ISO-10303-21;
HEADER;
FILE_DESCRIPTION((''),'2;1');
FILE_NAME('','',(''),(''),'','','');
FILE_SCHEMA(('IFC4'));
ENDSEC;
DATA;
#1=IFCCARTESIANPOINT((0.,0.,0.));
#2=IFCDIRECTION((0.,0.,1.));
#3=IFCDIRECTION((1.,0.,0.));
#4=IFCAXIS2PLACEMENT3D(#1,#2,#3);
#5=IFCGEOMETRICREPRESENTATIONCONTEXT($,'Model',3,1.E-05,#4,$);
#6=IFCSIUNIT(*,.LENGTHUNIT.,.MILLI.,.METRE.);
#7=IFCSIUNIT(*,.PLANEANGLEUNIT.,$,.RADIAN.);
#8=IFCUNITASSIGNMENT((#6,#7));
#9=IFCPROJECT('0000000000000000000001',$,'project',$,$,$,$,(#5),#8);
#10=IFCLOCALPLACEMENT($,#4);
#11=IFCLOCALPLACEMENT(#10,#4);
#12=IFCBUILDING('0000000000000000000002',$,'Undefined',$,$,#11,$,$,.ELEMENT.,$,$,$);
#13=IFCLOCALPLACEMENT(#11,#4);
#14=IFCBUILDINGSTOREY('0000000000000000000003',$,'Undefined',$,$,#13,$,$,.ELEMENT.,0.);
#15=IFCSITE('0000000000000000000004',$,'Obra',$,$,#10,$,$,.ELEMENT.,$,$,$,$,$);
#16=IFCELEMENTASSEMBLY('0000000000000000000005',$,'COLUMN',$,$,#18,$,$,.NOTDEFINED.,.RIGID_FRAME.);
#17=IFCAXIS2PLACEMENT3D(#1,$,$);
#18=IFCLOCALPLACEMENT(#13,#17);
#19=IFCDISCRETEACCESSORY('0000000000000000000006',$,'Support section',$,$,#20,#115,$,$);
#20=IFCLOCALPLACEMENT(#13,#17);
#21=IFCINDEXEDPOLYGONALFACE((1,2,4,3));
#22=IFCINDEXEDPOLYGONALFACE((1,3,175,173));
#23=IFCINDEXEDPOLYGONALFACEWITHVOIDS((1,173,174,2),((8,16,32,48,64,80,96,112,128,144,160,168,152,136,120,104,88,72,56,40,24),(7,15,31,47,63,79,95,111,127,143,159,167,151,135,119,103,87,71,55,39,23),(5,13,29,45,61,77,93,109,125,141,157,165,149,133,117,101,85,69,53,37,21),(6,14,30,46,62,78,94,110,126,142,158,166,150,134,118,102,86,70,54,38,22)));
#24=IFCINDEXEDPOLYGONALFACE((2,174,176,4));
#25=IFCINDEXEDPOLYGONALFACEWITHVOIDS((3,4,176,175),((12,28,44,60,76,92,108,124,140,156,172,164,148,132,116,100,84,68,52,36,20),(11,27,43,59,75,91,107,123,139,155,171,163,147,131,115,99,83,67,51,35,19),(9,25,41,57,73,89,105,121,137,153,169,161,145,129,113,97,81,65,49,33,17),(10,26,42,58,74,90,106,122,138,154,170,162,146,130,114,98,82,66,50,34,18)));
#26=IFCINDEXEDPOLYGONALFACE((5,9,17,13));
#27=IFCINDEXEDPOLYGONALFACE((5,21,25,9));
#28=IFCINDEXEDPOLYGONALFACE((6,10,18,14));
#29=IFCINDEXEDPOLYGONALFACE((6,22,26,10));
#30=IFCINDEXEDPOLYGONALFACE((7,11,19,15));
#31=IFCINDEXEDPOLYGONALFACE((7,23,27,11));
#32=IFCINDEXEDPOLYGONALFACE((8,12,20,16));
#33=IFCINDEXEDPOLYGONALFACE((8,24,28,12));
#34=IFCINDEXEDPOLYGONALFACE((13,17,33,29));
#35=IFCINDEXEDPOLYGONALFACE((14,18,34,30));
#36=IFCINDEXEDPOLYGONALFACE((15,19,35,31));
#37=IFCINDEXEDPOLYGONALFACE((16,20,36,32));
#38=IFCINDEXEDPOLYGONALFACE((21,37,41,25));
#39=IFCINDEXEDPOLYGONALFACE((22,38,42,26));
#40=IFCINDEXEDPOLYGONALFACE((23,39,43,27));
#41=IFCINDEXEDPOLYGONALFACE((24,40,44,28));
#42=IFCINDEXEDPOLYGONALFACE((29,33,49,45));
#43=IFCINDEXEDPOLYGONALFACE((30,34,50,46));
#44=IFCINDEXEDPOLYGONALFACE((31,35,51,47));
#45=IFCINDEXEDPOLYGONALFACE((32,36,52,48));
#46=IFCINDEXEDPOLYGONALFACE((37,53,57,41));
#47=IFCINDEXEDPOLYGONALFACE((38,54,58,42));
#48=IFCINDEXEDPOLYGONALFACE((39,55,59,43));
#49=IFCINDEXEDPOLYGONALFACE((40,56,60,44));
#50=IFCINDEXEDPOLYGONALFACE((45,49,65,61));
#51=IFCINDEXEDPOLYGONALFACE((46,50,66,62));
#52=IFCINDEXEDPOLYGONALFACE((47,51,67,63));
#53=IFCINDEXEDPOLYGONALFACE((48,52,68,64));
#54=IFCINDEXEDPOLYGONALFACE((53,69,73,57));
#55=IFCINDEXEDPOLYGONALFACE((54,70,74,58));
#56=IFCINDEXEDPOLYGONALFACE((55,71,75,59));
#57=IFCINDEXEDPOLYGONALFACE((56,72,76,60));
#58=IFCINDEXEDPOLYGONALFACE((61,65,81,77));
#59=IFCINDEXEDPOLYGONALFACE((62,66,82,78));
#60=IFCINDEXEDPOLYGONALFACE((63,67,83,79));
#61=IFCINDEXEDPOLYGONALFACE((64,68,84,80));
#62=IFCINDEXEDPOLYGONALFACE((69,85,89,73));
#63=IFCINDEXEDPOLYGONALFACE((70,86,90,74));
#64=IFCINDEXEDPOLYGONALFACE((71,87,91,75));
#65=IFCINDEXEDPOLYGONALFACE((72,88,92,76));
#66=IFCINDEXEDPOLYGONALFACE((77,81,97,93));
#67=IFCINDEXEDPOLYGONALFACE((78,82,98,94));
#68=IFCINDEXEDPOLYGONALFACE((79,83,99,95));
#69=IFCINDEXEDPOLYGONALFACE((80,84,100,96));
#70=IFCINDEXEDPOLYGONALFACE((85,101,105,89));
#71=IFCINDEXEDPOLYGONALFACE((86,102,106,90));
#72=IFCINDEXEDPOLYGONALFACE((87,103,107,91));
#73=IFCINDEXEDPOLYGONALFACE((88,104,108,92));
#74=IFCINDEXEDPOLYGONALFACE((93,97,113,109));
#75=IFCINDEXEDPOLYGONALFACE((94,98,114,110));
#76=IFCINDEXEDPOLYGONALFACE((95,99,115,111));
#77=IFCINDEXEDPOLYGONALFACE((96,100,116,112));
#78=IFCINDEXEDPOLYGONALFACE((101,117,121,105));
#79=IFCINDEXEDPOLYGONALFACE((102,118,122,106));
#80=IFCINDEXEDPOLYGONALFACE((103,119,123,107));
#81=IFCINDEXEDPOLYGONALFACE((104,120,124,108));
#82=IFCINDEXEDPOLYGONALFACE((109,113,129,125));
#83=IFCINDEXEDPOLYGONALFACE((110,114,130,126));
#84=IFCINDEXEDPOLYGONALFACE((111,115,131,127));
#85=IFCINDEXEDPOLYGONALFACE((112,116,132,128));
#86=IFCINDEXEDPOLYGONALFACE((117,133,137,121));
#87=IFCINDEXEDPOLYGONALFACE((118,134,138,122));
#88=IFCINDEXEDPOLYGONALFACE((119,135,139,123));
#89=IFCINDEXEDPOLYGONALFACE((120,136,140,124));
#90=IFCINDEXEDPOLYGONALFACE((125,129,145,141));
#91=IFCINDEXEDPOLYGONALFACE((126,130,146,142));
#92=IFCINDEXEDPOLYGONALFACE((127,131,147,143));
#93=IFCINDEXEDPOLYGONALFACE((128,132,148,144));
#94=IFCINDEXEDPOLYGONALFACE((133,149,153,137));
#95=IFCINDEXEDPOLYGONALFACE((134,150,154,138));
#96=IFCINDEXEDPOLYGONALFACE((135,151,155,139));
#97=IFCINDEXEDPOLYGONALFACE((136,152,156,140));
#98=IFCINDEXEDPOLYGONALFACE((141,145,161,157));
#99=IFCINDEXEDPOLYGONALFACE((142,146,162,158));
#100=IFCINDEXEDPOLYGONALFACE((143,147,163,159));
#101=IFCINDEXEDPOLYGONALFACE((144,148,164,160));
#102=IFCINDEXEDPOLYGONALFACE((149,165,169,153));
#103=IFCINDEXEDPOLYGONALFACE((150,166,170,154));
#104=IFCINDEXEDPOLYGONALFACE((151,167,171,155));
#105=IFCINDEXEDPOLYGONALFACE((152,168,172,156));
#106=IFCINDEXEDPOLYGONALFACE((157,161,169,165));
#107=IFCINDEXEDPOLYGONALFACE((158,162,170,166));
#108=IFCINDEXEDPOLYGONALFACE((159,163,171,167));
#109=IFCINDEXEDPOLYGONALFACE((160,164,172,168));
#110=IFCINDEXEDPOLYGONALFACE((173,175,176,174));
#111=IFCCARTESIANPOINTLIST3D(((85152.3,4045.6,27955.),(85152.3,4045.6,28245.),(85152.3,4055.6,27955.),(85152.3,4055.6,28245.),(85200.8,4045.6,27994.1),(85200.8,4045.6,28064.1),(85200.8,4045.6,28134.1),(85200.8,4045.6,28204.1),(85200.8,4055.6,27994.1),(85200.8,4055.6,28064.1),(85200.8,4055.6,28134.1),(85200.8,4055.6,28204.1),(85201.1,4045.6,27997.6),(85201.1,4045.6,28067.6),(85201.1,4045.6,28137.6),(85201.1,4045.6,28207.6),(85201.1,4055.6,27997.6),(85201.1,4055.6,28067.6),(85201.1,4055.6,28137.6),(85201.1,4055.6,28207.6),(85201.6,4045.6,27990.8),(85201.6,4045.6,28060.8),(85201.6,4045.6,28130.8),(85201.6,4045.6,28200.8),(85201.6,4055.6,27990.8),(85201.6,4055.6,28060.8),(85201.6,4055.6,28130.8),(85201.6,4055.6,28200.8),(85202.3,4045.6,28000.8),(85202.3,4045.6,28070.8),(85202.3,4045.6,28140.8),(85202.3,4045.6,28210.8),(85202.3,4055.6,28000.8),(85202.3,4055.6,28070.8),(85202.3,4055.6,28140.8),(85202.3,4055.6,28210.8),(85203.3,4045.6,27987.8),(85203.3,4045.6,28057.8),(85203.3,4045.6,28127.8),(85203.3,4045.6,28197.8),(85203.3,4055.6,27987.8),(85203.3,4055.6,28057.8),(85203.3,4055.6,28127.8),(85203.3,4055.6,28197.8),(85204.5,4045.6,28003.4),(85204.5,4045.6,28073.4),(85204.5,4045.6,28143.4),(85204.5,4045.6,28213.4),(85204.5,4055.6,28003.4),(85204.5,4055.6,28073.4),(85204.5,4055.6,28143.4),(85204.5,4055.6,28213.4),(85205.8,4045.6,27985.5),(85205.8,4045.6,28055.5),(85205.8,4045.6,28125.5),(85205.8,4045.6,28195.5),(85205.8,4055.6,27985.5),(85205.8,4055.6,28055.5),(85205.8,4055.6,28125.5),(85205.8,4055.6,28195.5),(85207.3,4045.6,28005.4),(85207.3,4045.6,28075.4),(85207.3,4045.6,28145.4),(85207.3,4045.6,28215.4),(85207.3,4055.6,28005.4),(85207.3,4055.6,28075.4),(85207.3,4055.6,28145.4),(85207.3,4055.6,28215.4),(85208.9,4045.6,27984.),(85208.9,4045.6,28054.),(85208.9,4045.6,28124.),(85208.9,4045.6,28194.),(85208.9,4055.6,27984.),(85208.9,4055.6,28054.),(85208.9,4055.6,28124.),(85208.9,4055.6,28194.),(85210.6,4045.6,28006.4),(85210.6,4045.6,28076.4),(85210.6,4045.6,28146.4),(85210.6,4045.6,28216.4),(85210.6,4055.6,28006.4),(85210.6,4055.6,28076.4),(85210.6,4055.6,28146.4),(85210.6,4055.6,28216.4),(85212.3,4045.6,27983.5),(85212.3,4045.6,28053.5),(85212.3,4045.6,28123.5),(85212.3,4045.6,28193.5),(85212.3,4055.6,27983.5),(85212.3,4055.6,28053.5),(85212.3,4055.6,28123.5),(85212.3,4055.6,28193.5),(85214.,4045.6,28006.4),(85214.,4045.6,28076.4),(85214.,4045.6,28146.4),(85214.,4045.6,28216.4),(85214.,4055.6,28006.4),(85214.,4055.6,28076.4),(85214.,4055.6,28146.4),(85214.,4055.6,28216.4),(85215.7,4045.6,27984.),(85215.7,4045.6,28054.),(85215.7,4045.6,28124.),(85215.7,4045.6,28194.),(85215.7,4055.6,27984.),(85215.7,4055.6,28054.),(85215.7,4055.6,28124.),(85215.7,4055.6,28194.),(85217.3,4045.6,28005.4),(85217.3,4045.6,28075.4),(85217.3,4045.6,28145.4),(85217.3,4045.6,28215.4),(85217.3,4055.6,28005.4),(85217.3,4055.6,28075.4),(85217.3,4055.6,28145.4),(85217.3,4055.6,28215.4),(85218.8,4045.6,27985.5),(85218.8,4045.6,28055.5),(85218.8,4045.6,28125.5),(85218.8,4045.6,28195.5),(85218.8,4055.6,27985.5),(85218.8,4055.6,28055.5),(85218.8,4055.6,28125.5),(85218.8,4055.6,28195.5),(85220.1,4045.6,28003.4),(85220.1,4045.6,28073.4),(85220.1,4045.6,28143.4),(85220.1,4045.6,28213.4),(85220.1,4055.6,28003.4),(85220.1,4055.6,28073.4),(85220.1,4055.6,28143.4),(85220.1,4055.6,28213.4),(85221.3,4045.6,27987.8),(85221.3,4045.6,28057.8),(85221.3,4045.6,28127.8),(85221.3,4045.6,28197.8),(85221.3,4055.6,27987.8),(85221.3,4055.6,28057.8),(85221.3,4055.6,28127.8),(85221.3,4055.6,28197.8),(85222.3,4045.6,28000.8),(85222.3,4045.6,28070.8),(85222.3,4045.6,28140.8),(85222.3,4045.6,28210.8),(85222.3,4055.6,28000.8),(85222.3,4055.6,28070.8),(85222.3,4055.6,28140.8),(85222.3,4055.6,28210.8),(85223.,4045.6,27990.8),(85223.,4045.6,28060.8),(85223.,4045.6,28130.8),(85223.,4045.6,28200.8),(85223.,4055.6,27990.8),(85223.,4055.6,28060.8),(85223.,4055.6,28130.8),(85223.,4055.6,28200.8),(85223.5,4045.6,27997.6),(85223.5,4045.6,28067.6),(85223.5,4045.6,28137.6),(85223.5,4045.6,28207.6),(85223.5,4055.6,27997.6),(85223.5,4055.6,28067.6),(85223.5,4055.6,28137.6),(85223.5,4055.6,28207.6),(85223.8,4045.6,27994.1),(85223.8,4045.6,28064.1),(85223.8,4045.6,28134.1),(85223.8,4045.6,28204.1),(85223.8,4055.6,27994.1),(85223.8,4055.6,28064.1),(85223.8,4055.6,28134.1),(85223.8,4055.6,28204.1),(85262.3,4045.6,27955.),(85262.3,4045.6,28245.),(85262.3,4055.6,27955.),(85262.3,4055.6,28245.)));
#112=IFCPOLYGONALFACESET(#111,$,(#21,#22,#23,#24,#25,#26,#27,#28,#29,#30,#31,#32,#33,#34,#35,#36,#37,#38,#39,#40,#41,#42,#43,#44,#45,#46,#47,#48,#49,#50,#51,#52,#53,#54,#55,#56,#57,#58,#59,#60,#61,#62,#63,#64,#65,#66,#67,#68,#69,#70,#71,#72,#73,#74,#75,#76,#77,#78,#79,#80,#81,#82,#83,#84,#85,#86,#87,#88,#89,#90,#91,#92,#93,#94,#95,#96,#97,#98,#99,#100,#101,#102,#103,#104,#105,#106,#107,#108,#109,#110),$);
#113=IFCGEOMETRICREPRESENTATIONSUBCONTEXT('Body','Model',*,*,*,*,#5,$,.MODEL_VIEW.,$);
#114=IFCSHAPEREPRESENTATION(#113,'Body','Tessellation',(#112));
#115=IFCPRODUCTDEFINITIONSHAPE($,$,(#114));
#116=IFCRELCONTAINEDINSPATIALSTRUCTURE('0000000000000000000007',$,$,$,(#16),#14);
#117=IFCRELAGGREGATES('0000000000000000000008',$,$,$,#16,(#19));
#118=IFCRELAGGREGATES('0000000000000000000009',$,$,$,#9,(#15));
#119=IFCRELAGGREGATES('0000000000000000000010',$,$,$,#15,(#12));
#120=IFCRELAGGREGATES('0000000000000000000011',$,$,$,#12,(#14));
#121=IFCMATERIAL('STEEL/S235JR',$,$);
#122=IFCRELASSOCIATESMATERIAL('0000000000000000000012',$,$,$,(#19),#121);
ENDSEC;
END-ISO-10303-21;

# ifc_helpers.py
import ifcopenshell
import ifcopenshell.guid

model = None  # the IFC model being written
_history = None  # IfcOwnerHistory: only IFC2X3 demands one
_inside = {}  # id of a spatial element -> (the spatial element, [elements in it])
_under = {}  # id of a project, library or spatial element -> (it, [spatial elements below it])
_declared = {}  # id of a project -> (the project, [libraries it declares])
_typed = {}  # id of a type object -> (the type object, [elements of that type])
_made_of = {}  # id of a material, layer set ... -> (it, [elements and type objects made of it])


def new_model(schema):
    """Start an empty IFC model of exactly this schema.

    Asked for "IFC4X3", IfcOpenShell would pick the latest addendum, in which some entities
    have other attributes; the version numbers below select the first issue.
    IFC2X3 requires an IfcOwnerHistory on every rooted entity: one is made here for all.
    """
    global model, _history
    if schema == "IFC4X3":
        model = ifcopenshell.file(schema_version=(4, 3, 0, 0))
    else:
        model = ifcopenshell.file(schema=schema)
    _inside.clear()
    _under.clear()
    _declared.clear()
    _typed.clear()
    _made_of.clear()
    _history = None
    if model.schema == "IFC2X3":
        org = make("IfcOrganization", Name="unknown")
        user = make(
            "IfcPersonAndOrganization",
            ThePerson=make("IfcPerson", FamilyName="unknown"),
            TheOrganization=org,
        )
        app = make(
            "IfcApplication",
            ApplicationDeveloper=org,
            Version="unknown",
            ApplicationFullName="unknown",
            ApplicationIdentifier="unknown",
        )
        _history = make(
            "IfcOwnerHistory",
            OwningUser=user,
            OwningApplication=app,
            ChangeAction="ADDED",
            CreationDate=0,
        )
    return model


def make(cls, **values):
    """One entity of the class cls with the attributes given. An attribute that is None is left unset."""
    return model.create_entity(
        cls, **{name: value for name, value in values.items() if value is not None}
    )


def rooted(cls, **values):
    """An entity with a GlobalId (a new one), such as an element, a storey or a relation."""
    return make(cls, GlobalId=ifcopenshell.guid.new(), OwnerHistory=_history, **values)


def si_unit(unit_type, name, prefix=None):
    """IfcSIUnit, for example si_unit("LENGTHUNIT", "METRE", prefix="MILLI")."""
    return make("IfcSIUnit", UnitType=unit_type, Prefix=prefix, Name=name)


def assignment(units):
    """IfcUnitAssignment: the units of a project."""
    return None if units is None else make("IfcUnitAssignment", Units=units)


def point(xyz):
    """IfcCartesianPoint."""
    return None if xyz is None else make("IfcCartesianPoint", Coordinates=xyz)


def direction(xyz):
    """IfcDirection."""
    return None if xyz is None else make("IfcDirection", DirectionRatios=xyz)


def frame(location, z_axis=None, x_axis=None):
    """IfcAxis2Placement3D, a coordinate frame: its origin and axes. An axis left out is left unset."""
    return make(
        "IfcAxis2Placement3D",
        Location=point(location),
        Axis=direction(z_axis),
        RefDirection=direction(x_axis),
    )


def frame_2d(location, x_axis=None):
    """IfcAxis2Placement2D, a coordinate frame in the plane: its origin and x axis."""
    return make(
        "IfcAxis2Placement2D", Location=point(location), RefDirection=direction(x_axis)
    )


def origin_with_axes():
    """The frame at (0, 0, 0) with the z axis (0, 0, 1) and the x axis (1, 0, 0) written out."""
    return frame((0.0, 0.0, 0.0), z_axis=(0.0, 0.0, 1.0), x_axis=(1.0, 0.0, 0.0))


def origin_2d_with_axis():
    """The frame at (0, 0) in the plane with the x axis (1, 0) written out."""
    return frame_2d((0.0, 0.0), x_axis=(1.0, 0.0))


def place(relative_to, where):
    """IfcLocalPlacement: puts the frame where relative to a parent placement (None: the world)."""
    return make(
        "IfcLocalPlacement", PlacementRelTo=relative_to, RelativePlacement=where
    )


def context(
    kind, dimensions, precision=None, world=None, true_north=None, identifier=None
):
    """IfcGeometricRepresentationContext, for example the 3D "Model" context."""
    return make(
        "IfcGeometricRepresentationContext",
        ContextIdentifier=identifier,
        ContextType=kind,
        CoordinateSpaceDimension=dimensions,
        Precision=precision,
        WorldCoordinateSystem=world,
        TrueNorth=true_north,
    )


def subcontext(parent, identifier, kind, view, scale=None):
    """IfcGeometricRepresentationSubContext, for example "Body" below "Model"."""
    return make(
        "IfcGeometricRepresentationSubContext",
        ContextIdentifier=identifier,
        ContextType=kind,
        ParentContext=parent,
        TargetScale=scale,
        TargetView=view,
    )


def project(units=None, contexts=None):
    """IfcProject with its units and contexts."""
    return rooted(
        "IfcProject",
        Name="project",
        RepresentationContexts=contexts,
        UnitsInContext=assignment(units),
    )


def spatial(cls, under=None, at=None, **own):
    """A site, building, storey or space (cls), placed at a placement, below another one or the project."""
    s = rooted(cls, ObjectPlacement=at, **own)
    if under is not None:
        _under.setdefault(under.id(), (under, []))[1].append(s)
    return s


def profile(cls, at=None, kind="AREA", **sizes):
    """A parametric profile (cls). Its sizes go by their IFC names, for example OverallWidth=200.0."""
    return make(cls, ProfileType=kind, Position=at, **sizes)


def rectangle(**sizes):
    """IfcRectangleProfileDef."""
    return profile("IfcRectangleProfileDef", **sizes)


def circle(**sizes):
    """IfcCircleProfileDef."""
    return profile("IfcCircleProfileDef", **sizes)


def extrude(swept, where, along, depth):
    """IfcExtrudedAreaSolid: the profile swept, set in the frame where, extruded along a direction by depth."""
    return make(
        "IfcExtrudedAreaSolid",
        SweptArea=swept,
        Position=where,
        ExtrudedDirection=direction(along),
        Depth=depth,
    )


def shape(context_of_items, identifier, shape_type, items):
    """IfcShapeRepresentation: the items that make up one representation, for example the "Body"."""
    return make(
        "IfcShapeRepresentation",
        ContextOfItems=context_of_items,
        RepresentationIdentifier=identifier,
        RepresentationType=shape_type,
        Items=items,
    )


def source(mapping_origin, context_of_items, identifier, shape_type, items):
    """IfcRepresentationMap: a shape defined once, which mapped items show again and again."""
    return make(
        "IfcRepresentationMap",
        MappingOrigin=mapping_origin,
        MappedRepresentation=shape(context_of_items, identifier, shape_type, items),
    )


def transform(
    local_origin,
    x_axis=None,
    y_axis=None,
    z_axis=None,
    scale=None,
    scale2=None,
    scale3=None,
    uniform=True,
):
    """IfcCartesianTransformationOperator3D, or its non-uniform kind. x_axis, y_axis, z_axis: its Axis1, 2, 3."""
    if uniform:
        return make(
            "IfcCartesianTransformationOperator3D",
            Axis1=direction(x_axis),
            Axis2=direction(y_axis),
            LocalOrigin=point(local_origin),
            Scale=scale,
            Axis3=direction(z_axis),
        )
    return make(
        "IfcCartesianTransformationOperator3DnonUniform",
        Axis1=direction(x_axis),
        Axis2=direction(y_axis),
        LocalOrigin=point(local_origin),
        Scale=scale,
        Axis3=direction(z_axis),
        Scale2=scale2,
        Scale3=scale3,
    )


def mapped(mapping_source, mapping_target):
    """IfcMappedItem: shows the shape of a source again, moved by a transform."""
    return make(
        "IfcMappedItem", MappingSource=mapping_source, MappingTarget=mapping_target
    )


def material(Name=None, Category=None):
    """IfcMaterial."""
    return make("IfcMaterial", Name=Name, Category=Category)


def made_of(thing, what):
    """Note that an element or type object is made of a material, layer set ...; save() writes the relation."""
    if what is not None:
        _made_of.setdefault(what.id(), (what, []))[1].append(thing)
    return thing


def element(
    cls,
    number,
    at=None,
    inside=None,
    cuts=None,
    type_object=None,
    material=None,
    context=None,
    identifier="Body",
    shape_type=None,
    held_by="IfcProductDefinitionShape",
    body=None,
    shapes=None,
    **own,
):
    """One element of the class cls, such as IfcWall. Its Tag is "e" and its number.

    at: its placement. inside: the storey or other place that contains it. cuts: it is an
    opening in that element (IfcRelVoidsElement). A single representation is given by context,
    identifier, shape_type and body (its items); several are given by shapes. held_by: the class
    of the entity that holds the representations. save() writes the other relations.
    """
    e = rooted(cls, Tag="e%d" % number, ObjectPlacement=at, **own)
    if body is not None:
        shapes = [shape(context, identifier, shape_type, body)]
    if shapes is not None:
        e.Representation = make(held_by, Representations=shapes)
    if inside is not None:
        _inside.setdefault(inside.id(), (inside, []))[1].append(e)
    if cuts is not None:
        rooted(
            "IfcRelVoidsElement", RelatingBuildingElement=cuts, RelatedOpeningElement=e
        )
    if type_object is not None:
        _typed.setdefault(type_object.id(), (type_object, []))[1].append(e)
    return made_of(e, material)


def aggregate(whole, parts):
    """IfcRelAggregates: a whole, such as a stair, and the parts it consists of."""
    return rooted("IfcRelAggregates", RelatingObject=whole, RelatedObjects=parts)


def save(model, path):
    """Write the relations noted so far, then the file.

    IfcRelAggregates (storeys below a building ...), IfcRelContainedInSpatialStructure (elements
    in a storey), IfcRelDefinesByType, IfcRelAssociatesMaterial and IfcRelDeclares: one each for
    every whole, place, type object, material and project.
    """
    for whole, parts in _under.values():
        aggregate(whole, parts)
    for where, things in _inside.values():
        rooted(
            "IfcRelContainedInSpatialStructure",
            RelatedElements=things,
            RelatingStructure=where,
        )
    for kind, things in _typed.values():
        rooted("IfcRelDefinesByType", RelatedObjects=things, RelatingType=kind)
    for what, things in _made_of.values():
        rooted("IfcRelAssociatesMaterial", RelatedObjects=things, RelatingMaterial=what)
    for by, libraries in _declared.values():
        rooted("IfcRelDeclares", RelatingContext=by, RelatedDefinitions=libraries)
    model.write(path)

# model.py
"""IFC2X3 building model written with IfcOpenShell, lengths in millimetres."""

from ifc_helpers import new_model, si_unit, frame, origin_with_axes, origin_2d_with_axis, place, context, subcontext, project, spatial, rectangle, circle, extrude, source, transform, mapped, material, element, aggregate, save


model = new_model("IFC2X3")

# Units and contexts
model_context = context("Model", 3, precision=1e-05, world=origin_with_axes())
body_context = subcontext(model_context, "Body", "Model", "MODEL_VIEW")
ifc_project = project(units=[si_unit("LENGTHUNIT", "METRE", prefix="MILLI"), si_unit("PLANEANGLEUNIT", "RADIAN")], contexts=[model_context])

# Site, building, storey
site_placement = place(None, origin_with_axes())
site = spatial("IfcSite", under=ifc_project, at=site_placement, Name="Obra", CompositionType="ELEMENT")
building_placement = place(site_placement, origin_with_axes())
building = spatial("IfcBuilding", under=site, at=building_placement, Name="Undefined", CompositionType="ELEMENT")
storey_placement = place(building_placement, origin_with_axes())
storey = spatial("IfcBuildingStorey", under=building, at=storey_placement, Name="Undefined", CompositionType="ELEMENT", Elevation=0.0)

# Shared definitions
ifc_material = material(Name="STEEL/S235JR")

# Shared definitions
shared_shape_1 = source(origin_with_axes(), body_context, "Body", "SweptSolid", [
    extrude(circle(Radius=11.5, at=origin_2d_with_axis()), frame((0.0, -14.4, 0.0), z_axis=(0.0, 1.0, 0.0), x_axis=(1.0, 0.0, 0.0)), (0.0, 0.0, 1.0), 10.2),
])

# Element assembly, discrete accessory, opening
assembly_1_placement = place(storey_placement, origin_with_axes())
assembly_1 = element("IfcElementAssembly", 1, at=assembly_1_placement, inside=storey, Name="COLUMN", AssemblyPlace="NOTDEFINED", PredefinedType="RIGID_FRAME")
discrete_accessory_1_placement = place(assembly_1_placement, frame((85207.3, 4050.6, 27955.0), z_axis=(0.0, 0.0, 1.0), x_axis=(-1.0, 0.0, 0.0)))
discrete_accessory_1 = element("IfcDiscreteAccessory", 2, at=discrete_accessory_1_placement, material=ifc_material, Name="Support section", context=body_context, shape_type="SweptSolid", body=[
    extrude(rectangle(XDim=10.0, YDim=110.0, at=origin_2d_with_axis()), frame((0.0, 0.0, 290.0), z_axis=(0.0, 0.0, -1.0), x_axis=(0.0, 1.0, 0.0)), (0.0, 0.0, 1.0), 290.0),
])
opening_1_placement = place(assembly_1_placement, frame((85162.3, 4059.9, 28300.0), z_axis=(1.0, 0.0, 0.0), x_axis=(0.0, 0.0, -1.0)))
element("IfcOpeningElement", 3, at=opening_1_placement, cuts=discrete_accessory_1, ObjectType="Opening", context=body_context, shape_type="MappedRepresentation", body=[
    mapped(shared_shape_1, transform((95.0, 0.0, 50.0))),
    mapped(shared_shape_1, transform((165.0, 0.0, 50.0))),
    mapped(shared_shape_1, transform((235.0, 0.0, 50.0))),
    mapped(shared_shape_1, transform((305.0, 0.0, 50.0))),
])
aggregate(assembly_1, [discrete_accessory_1])

save(model, "model.ifc")
